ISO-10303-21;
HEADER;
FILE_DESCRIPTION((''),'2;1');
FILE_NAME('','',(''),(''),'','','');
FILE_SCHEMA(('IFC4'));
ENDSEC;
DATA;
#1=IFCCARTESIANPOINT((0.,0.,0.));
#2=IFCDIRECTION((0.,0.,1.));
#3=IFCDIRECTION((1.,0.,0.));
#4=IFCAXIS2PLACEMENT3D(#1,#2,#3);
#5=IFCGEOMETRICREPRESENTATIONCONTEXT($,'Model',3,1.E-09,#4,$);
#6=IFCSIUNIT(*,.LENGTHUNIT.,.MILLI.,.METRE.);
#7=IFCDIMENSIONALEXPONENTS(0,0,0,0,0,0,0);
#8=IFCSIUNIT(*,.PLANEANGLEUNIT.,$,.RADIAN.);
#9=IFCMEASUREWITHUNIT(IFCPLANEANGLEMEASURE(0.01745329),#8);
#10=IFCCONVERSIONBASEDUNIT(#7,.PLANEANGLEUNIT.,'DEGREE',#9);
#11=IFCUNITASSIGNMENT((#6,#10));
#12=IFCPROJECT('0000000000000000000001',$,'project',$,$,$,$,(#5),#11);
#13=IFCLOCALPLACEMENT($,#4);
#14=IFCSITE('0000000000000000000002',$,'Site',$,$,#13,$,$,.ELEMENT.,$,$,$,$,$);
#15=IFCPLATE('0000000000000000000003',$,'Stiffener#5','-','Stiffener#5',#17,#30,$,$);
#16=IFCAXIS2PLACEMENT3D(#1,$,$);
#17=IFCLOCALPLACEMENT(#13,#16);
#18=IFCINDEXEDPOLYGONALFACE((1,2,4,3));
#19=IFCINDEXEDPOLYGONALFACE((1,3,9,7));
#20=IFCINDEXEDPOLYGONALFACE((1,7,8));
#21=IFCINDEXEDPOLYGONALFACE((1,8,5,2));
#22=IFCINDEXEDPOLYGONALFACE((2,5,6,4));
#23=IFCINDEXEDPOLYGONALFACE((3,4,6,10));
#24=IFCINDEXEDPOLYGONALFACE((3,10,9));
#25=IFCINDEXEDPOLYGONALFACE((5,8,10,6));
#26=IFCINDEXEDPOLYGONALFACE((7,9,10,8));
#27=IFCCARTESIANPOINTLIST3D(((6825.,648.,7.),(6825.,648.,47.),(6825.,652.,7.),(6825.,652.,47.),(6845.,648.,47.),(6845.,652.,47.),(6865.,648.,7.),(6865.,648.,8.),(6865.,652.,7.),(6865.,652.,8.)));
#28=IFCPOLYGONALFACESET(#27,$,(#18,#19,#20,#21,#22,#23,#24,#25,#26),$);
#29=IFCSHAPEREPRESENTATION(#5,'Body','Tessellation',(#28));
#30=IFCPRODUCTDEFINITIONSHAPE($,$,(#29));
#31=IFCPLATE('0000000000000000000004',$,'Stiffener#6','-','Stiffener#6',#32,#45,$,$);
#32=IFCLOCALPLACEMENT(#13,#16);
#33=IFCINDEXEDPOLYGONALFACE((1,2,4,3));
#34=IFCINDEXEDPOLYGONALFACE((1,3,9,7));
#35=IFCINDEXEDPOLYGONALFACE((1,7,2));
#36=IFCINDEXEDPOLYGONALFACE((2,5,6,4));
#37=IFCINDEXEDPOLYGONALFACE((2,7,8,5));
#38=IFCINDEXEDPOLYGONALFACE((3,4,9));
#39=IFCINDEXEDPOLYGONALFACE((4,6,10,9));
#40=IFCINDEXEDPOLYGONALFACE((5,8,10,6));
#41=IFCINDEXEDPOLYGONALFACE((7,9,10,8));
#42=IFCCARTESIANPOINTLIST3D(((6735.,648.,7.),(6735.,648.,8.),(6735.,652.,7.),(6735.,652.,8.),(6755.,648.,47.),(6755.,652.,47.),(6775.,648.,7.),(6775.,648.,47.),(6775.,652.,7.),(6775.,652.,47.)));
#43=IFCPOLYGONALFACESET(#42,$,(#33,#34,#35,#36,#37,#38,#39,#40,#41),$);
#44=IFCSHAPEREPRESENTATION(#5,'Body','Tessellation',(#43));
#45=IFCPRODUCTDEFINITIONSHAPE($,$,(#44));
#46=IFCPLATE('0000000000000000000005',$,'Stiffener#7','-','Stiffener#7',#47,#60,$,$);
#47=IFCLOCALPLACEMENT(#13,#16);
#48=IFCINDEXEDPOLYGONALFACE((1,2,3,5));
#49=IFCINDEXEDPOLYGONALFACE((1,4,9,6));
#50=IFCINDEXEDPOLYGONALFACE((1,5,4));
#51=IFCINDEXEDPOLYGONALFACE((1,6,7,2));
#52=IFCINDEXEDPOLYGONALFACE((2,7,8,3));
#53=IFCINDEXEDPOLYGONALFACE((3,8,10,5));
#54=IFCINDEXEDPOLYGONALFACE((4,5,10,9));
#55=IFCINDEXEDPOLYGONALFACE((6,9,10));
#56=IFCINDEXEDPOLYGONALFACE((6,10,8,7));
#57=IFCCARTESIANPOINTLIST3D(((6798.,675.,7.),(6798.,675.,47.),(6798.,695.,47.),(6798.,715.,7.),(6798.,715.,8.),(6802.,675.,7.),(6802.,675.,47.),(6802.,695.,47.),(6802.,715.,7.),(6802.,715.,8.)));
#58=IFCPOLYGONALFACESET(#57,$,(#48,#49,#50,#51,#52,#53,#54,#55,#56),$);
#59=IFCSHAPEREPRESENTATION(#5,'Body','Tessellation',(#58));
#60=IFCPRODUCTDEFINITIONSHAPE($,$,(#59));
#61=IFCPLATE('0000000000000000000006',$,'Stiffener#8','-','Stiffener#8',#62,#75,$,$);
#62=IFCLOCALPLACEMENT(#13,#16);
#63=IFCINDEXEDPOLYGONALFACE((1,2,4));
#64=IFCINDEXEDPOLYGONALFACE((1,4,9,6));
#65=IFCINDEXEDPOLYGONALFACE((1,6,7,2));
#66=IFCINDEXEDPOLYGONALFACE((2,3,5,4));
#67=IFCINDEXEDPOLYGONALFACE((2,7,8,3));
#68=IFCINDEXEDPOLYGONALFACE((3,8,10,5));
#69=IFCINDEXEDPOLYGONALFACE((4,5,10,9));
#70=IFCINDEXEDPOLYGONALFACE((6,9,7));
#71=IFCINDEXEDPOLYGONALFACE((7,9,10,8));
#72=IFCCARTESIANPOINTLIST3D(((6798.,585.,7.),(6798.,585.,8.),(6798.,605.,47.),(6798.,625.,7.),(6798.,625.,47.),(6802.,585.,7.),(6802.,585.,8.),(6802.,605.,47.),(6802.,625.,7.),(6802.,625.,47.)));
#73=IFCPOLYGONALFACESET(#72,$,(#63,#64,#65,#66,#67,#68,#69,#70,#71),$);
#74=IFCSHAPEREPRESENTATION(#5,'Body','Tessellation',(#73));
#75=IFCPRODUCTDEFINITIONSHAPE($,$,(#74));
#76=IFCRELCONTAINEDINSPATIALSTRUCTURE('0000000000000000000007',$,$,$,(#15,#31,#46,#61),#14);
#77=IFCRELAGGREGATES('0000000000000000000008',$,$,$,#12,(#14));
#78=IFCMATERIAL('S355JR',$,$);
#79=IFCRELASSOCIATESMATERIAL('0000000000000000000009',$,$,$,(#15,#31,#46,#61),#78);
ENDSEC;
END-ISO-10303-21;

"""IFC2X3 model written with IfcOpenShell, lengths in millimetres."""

from ifc_helpers import new_model, entity, si_unit, converted_unit, frame, origin, origin_with_axes, place, context, project, spatial, polyline, outline, extrude, material, element, save


model = new_model("IFC2X3")

# Units and contexts
model_context = context("Model", 3, precision=1e-09, world=origin_with_axes())
ifc_project = project(units=[si_unit("LENGTHUNIT", "METRE", prefix="MILLI"), converted_unit("PLANEANGLEUNIT", "DEGREE", entity("IfcPlaneAngleMeasure", 0.01745329), si_unit("PLANEANGLEUNIT", "RADIAN"), dimensions=[0, 0, 0, 0, 0, 0, 0])], contexts=[model_context])

# Site
site_placement = place(None, origin_with_axes())
site = spatial("IfcSite", under=ifc_project, at=site_placement, Name="Site", CompositionType="ELEMENT")

# Shared definitions
ifc_material = material(Name="S355JR")

# Plates, openings
plate_1_placement = place(None, frame((6825.0, 648.0, 7.0), z_axis=(0.0, 1.0, 0.0), x_axis=(0.0, 0.0, 1.0)))
plate_1 = element("IfcPlate", 1, at=plate_1_placement, inside=site, material=ifc_material, Name="Stiffener#5", Description="-", ObjectType="Stiffener#5", context=model_context, shape_type="SweptSolid", body=[
    extrude(outline(polyline([(0.0, 0.0), (40.0, 0.0), (40.0, 40.0), (0.0, 40.0), (0.0, 0.0)])), origin_with_axes(), (0.0, 0.0, 1.0), 4.0),
])
opening_1_placement = place(plate_1_placement, frame((0.0, 0.0, 0.0), z_axis=(0.0, 0.0, 1.0), x_axis=(1.0, 0.0, 0.0)))
element("IfcOpeningElement", 2, at=opening_1_placement, cuts=plate_1, ObjectType="Opening", context=model_context, shape_type="SweptSolid", body=[
    extrude(outline(polyline([(40.0, 40.0), (1.0, 40.0), (40.0, 20.0), (40.0, 40.0)])), origin(), (0.0, 0.0, 1.0), 4.0),
])
plate_2_placement = place(None, frame((6775.0, 648.0, 7.0), z_axis=(0.0, 1.0, 0.0), x_axis=(-1.0, 0.0, 0.0)))
plate_2 = element("IfcPlate", 3, at=plate_2_placement, inside=site, material=ifc_material, Name="Stiffener#6", Description="-", ObjectType="Stiffener#6", context=model_context, shape_type="SweptSolid", body=[
    extrude(outline(polyline([(0.0, 0.0), (40.0, 0.0), (40.0, 40.0), (0.0, 40.0), (0.0, 0.0)])), origin_with_axes(), (0.0, 0.0, 1.0), 4.0),
])
opening_2_placement = place(plate_2_placement, frame((0.0, 0.0, 0.0), z_axis=(0.0, 0.0, 1.0), x_axis=(1.0, 0.0, 0.0)))
element("IfcOpeningElement", 4, at=opening_2_placement, cuts=plate_2, ObjectType="Opening", context=model_context, shape_type="SweptSolid", body=[
    extrude(outline(polyline([(40.0, 40.0), (20.0, 40.0), (40.0, 1.0), (40.0, 40.0)])), origin(), (0.0, 0.0, 1.0), 4.0),
])
plate_3_placement = place(None, frame((6802.0, 675.0, 7.0), z_axis=(-1.0, 0.0, 0.0), x_axis=(0.0, 0.0, 1.0)))
plate_3 = element("IfcPlate", 5, at=plate_3_placement, inside=site, material=ifc_material, Name="Stiffener#7", Description="-", ObjectType="Stiffener#7", context=model_context, shape_type="SweptSolid", body=[
    extrude(outline(polyline([(0.0, 0.0), (40.0, 0.0), (40.0, 40.0), (0.0, 40.0), (0.0, 0.0)])), origin_with_axes(), (0.0, 0.0, 1.0), 4.0),
])
opening_3_placement = place(plate_3_placement, frame((0.0, 0.0, 0.0), z_axis=(0.0, 0.0, 1.0), x_axis=(1.0, 0.0, 0.0)))
element("IfcOpeningElement", 6, at=opening_3_placement, cuts=plate_3, ObjectType="Opening", context=model_context, shape_type="SweptSolid", body=[
    extrude(outline(polyline([(40.0, 40.0), (1.0, 40.0), (40.0, 20.0), (40.0, 40.0)])), origin(), (0.0, 0.0, 1.0), 4.0),
])
plate_4_placement = place(None, frame((6802.0, 625.0, 7.0), z_axis=(-1.0, 0.0, 0.0), x_axis=(0.0, -1.0, 0.0)))
plate_4 = element("IfcPlate", 7, at=plate_4_placement, inside=site, material=ifc_material, Name="Stiffener#8", Description="-", ObjectType="Stiffener#8", context=model_context, shape_type="SweptSolid", body=[
    extrude(outline(polyline([(0.0, 0.0), (40.0, 0.0), (40.0, 40.0), (0.0, 40.0), (0.0, 0.0)])), origin_with_axes(), (0.0, 0.0, 1.0), 4.0),
])
opening_4_placement = place(plate_4_placement, frame((0.0, 0.0, 0.0), z_axis=(0.0, 0.0, 1.0), x_axis=(1.0, 0.0, 0.0)))
element("IfcOpeningElement", 8, at=opening_4_placement, cuts=plate_4, ObjectType="Opening", context=model_context, shape_type="SweptSolid", body=[
    extrude(outline(polyline([(40.0, 40.0), (20.0, 40.0), (40.0, 1.0), (40.0, 40.0)])), origin(), (0.0, 0.0, 1.0), 4.0),
])

save(model, "model.ifc")
